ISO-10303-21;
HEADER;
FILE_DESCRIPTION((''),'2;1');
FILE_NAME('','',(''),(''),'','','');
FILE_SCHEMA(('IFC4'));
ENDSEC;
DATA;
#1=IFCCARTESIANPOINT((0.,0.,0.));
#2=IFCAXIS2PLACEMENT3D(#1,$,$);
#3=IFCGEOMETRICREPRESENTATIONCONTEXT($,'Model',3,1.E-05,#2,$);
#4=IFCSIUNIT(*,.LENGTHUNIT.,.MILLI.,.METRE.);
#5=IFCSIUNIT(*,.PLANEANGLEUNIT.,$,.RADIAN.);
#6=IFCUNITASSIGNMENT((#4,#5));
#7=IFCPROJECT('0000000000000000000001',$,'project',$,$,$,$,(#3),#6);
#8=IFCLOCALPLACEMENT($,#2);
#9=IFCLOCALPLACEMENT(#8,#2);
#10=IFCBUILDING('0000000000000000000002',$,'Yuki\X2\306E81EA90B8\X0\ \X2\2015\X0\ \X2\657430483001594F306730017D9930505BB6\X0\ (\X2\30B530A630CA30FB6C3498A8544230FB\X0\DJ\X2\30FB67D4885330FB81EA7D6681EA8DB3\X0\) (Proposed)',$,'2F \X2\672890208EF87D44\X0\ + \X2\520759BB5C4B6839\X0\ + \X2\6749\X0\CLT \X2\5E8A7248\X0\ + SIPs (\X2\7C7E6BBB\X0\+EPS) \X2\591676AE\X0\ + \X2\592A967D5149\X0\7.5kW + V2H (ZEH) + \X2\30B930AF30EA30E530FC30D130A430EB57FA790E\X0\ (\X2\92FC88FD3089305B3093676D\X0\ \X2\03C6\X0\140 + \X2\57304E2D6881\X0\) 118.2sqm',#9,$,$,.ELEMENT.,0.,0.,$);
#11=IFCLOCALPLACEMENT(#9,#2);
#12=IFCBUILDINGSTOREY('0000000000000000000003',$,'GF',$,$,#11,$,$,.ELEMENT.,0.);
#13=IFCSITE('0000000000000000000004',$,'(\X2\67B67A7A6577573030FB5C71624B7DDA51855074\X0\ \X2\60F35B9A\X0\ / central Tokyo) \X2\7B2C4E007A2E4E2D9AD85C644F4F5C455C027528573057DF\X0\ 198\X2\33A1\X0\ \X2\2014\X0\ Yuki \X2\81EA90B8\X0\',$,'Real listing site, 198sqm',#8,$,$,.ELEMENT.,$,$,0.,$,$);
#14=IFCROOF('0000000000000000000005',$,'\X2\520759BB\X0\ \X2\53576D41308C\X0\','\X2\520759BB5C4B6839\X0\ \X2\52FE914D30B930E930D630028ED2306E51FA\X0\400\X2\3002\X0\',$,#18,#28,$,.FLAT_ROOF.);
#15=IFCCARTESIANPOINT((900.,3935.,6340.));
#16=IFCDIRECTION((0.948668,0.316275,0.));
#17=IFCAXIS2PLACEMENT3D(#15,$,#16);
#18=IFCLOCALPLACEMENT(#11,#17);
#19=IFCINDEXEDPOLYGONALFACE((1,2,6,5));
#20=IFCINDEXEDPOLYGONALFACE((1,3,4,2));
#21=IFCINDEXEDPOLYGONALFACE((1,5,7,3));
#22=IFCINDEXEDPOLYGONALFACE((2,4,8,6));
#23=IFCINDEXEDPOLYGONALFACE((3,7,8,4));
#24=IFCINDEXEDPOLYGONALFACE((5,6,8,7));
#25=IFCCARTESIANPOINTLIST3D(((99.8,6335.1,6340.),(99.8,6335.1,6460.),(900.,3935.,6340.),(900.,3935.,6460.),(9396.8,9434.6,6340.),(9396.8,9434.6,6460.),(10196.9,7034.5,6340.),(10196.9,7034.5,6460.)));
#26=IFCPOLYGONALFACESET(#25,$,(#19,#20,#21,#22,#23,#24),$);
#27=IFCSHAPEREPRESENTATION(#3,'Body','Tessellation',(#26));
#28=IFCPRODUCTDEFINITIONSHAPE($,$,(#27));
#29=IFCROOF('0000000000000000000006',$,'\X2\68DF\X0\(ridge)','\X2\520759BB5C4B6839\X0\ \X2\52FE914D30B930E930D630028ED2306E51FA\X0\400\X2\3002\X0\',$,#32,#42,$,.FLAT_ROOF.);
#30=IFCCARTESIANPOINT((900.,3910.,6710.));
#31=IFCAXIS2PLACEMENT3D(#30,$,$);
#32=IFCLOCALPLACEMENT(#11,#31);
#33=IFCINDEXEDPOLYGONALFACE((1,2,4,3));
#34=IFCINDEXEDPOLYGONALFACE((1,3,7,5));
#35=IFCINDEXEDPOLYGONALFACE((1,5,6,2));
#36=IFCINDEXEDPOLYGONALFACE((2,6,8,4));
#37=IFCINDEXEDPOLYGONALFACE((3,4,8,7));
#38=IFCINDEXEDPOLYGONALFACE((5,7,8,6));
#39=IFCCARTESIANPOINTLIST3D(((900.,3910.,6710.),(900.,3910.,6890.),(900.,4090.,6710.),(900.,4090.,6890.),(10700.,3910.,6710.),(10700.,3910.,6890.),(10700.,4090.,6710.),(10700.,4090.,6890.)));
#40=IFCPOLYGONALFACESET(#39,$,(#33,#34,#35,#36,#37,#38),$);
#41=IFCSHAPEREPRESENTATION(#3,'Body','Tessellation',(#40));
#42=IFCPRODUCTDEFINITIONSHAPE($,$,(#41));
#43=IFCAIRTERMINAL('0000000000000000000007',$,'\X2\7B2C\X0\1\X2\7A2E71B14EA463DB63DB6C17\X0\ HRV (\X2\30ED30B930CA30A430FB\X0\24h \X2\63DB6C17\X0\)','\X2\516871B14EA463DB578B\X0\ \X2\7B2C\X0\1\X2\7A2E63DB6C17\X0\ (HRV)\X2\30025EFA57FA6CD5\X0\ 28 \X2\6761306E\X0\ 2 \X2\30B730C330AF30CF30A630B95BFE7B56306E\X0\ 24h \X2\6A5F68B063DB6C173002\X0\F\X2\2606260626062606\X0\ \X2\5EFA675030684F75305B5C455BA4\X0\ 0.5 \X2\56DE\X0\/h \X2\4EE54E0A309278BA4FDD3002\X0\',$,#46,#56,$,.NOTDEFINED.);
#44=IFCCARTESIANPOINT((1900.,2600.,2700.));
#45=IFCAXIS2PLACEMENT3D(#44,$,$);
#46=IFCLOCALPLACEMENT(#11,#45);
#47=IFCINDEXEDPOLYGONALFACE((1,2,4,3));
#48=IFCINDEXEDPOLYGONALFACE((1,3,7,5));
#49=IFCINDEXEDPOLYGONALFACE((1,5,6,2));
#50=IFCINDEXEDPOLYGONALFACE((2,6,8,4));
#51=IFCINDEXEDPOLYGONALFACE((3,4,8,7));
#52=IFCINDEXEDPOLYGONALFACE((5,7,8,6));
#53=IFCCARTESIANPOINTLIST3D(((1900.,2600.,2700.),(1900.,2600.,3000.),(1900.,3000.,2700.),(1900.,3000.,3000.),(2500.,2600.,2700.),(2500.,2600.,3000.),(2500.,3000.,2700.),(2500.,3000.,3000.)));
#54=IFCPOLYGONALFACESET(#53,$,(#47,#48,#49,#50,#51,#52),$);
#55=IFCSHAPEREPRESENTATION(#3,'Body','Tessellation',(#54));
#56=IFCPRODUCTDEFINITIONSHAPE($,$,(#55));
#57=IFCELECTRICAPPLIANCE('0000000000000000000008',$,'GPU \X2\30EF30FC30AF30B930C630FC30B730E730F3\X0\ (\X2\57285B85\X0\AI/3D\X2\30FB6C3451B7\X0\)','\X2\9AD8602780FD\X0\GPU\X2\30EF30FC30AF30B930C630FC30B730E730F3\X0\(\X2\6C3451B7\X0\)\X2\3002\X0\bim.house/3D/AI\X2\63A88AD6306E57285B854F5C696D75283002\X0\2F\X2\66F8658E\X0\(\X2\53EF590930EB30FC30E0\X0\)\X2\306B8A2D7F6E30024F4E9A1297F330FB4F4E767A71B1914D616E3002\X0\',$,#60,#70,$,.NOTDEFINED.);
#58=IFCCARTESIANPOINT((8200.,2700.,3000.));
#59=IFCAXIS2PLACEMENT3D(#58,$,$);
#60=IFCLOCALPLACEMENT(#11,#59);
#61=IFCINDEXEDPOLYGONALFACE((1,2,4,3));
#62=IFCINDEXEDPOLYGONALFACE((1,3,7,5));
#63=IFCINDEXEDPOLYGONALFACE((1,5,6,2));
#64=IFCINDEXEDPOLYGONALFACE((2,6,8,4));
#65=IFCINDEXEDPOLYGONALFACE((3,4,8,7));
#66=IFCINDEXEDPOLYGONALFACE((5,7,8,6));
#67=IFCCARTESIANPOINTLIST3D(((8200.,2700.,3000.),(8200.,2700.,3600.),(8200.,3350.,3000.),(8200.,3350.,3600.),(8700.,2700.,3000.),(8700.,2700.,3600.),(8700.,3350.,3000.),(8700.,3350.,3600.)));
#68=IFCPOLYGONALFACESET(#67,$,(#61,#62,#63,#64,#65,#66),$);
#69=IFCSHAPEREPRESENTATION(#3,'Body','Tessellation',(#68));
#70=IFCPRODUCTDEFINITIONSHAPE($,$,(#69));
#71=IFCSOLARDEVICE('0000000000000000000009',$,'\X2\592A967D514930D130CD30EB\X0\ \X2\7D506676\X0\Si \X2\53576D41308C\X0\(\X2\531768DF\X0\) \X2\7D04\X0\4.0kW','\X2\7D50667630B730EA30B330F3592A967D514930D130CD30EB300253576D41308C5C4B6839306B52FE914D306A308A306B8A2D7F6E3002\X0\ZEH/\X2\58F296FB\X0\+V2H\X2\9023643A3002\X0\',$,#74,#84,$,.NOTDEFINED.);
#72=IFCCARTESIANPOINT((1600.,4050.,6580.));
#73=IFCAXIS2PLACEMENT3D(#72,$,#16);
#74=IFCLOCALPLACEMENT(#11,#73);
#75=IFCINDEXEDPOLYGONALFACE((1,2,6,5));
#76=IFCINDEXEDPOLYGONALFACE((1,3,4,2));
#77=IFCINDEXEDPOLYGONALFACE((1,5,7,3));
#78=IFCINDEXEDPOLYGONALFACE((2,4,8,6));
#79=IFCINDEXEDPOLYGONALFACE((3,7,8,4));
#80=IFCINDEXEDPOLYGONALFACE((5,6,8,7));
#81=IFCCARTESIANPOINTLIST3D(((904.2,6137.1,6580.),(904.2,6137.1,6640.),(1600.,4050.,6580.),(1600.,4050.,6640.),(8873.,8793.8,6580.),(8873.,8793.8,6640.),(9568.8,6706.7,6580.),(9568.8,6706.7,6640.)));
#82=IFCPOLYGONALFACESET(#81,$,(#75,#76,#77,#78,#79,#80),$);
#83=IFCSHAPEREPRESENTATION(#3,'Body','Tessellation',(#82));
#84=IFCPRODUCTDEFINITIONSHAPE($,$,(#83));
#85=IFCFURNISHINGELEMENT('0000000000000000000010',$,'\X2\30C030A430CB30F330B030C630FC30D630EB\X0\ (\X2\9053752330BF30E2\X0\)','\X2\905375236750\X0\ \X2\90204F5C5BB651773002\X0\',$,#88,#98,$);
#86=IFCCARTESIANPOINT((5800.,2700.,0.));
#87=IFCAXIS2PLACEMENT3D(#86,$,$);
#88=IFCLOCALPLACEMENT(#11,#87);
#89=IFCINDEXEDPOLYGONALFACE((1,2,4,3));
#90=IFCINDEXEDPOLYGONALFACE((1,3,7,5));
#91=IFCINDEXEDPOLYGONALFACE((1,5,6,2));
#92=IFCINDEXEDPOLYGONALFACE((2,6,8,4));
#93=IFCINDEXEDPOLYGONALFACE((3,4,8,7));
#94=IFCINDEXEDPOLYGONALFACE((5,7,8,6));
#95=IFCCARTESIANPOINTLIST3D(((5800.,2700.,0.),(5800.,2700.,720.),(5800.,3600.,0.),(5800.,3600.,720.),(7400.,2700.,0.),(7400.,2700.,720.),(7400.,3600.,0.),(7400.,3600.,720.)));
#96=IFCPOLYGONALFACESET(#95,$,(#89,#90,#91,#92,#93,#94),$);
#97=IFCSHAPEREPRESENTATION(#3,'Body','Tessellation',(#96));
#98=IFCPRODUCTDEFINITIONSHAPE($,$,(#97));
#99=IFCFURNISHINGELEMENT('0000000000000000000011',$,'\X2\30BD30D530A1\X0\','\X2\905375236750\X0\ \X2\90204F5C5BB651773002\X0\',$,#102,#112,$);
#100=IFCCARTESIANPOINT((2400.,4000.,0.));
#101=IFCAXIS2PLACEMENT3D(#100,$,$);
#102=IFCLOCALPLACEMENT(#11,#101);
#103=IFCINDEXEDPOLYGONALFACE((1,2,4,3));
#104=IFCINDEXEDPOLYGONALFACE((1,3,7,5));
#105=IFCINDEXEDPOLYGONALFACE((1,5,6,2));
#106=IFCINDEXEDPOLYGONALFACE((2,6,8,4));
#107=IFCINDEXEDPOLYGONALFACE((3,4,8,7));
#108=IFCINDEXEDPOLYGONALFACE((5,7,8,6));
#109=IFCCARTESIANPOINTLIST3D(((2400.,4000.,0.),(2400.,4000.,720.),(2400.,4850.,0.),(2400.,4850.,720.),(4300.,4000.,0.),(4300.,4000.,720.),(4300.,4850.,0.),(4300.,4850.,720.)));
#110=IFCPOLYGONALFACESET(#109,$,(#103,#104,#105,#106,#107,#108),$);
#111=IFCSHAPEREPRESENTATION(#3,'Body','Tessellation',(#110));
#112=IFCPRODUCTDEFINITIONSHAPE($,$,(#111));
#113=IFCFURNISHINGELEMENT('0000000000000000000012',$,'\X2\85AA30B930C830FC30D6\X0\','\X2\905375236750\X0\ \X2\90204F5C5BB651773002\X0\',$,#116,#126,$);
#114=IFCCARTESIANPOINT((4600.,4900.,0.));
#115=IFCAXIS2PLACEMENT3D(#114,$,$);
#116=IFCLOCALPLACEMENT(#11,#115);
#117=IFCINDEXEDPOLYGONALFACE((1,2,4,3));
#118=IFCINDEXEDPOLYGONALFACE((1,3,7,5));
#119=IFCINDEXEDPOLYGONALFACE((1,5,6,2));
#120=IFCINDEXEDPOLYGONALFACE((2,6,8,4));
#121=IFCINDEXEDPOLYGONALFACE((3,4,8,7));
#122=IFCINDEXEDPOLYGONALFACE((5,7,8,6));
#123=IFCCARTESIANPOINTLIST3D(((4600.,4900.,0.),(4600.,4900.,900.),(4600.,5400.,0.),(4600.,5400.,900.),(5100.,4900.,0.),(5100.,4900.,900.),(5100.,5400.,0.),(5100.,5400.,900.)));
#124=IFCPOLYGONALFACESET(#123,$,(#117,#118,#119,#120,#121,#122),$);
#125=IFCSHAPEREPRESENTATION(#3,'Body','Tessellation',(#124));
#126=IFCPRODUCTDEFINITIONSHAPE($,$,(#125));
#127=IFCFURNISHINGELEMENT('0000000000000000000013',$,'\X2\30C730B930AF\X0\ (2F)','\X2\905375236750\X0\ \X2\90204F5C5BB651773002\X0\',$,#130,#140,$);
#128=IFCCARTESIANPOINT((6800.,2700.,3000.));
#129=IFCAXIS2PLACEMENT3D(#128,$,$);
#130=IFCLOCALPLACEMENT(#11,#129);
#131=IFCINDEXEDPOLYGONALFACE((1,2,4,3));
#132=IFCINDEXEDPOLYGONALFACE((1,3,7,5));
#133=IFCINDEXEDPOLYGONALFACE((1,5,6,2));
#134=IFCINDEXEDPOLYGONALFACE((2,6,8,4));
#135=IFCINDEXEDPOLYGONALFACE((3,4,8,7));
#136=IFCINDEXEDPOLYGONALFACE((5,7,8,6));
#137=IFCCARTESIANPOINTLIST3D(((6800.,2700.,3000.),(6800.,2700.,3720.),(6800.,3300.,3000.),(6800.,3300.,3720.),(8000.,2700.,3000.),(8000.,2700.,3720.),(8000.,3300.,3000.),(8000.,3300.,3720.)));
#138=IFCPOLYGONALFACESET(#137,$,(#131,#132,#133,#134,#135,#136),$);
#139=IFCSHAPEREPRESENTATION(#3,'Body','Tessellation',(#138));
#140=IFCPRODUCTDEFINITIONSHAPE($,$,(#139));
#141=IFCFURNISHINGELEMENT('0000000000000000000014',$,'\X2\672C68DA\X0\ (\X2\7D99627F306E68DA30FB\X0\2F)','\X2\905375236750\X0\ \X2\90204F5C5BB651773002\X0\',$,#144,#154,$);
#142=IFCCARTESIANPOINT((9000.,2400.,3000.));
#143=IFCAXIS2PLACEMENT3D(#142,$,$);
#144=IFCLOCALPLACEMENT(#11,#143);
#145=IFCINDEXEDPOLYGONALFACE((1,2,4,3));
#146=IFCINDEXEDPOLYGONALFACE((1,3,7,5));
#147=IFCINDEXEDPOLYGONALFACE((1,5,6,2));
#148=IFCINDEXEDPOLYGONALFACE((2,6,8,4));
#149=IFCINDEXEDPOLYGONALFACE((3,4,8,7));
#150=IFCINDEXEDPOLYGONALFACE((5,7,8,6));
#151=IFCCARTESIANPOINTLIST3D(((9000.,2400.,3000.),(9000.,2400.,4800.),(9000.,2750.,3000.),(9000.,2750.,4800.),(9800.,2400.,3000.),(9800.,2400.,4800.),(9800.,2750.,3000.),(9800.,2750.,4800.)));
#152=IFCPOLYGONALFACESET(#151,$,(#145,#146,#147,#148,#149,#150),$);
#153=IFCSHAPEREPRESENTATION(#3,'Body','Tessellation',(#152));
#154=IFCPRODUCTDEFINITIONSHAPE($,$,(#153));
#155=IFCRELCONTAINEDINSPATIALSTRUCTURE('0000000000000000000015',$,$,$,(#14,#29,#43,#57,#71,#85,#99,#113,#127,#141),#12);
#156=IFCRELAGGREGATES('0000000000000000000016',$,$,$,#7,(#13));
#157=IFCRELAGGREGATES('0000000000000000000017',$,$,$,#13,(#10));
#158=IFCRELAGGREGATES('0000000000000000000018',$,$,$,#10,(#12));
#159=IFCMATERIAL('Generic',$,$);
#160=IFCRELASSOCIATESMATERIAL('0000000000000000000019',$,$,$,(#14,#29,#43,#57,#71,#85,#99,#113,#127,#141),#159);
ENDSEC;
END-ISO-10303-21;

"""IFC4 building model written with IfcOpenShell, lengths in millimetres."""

from ifc_helpers import new_model, si_unit, frame, frame_2d, origin, place, context, project, spatial, rectangle, extrude, material, element, save


model = new_model("IFC4")

# Units and contexts
model_context = context("Model", 3, precision=1e-05, world=origin())
ifc_project = project(units=[si_unit("LENGTHUNIT", "METRE", prefix="MILLI"), si_unit("PLANEANGLEUNIT", "RADIAN")], contexts=[model_context])

# Site, building, storey
site_placement = place(None, origin())
site = spatial("IfcSite", under=ifc_project, at=site_placement, Name="(架空敷地・山手線内側 想定 / central Tokyo) 第一種中高層住居専用地域 198㎡ — Yuki 自邸", ObjectType="Real listing site, 198sqm", CompositionType="ELEMENT", RefElevation=0.0)
building_placement = place(site_placement, origin())
building = spatial("IfcBuilding", under=site, at=building_placement, Name="Yukiの自邸 ― 整え、奏で、継ぐ家 (サウナ・水風呂・DJ・柔術・自給自足) (Proposed)", ObjectType="2F 木造軸組 + 切妻屋根 + 杉CLT 床版 + SIPs (籾殻+EPS) 外皮 + 太陽光7.5kW + V2H (ZEH) + スクリューパイル基礎 (鋼製らせん杭 φ140 + 地中梁) 118.2sqm", CompositionType="ELEMENT", ElevationOfRefHeight=0.0, ElevationOfTerrain=0.0)
storey_placement = place(building_placement, origin())
storey = spatial("IfcBuildingStorey", under=building, at=storey_placement, Name="GF", CompositionType="ELEMENT", Elevation=0.0)

# Shared definitions
ifc_material_1 = material(Name="Generic")

# Roofs
roof_1_placement = place(storey_placement, frame((900.0, 3935.0, 6340.0), x_axis=(0.948668, 0.316275, 0.0)))
element("IfcRoof", 1, at=roof_1_placement, inside=storey, material=ifc_material_1, Name="切妻 南流れ", Description="切妻屋根 勾配スラブ。軒の出400。", PredefinedType="FLAT_ROOF", context=model_context, shape_type="SweptSolid", body=[
    extrude(rectangle(XDim=9800.0, YDim=2530.0, at=frame_2d((4900.0, 1265.0))), frame((900.0, 3935.0, 6340.0), x_axis=(0.948668, 0.316275, 0.0)), (0.0, 0.0, 1.0), 120.0),
])
roof_2_placement = place(storey_placement, frame((900.0, 3910.0, 6710.0)))
element("IfcRoof", 2, at=roof_2_placement, inside=storey, material=ifc_material_1, Name="棟(ridge)", Description="切妻屋根 勾配スラブ。軒の出400。", PredefinedType="FLAT_ROOF", context=model_context, shape_type="SweptSolid", body=[
    extrude(rectangle(XDim=9800.0, YDim=180.0, at=frame_2d((4900.0, 90.0))), frame((900.0, 3910.0, 6710.0)), (0.0, 0.0, 1.0), 180.0),
])

# Air terminal
air_terminal_placement = place(storey_placement, frame((1900.0, 2600.0, 2700.0)))
element("IfcAirTerminal", 3, at=air_terminal_placement, inside=storey, material=ifc_material_1, Name="第1種熱交換換気 HRV (ロスナイ・24h 換気)", Description="全熱交換型 第1種換気 (HRV)。建基法 28 条の 2 シックハウス対策の 24h 機械換気。F☆☆☆☆ 建材と併せ居室 0.5 回/h 以上を確保。", PredefinedType="NOTDEFINED", context=model_context, shape_type="SweptSolid", body=[
    extrude(rectangle(XDim=600.0, YDim=400.0, at=frame_2d((300.0, 200.0))), frame((1900.0, 2600.0, 2700.0)), (0.0, 0.0, 1.0), 300.0),
])

# Electric appliance
electric_appliance_placement = place(storey_placement, frame((8200.0, 2700.0, 3000.0)))
element("IfcElectricAppliance", 4, at=electric_appliance_placement, inside=storey, material=ifc_material_1, Name="GPU ワークステーション (在宅AI/3D・水冷)", Description="高性能GPUワークステーション(水冷)。bim.house/3D/AI推論の在宅作業用。2F書斎(可変ルーム)に設置。低騒音・低発熱配慮。", PredefinedType="NOTDEFINED", context=model_context, shape_type="SweptSolid", body=[
    extrude(rectangle(XDim=500.0, YDim=650.0, at=frame_2d((250.0, 325.0))), frame((8200.0, 2700.0, 3000.0)), (0.0, 0.0, 1.0), 600.0),
])

# Solar device
solar_device_placement = place(storey_placement, frame((1600.0, 4050.0, 6580.0), x_axis=(0.948668, 0.316275, 0.0)))
element("IfcSolarDevice", 5, at=solar_device_placement, inside=storey, material=ifc_material_1, Name="太陽光パネル 結晶Si 南流れ(北棟) 約4.0kW", Description="結晶シリコン太陽光パネル。南流れ屋根に勾配なりに設置。ZEH/売電+V2H連携。", PredefinedType="NOTDEFINED", context=model_context, shape_type="SweptSolid", body=[
    extrude(rectangle(XDim=8400.0, YDim=2200.0, at=frame_2d((4200.0, 1100.0))), frame((1600.0, 4050.0, 6580.0), x_axis=(0.948668, 0.316275, 0.0)), (0.0, 0.0, 1.0), 60.0),
])

# Furnishing elements
furnishing_1_placement = place(storey_placement, frame((5800.0, 2700.0, 0.0)))
element("IfcFurnishingElement", 6, at=furnishing_1_placement, inside=storey, material=ifc_material_1, Name="ダイニングテーブル (道産タモ)", Description="道産材 造作家具。", context=model_context, shape_type="SweptSolid", body=[
    extrude(rectangle(XDim=1600.0, YDim=900.0, at=frame_2d((800.0, 450.0))), frame((5800.0, 2700.0, 0.0)), (0.0, 0.0, 1.0), 720.0),
])
furnishing_2_placement = place(storey_placement, frame((2400.0, 4000.0, 0.0)))
element("IfcFurnishingElement", 7, at=furnishing_2_placement, inside=storey, material=ifc_material_1, Name="ソファ", Description="道産材 造作家具。", context=model_context, shape_type="SweptSolid", body=[
    extrude(rectangle(XDim=1900.0, YDim=850.0, at=frame_2d((950.0, 425.0))), frame((2400.0, 4000.0, 0.0)), (0.0, 0.0, 1.0), 720.0),
])
furnishing_3_placement = place(storey_placement, frame((4600.0, 4900.0, 0.0)))
element("IfcFurnishingElement", 8, at=furnishing_3_placement, inside=storey, material=ifc_material_1, Name="薪ストーブ", Description="道産材 造作家具。", context=model_context, shape_type="SweptSolid", body=[
    extrude(rectangle(XDim=500.0, YDim=500.0, at=frame_2d((250.0, 250.0))), frame((4600.0, 4900.0, 0.0)), (0.0, 0.0, 1.0), 900.0),
])
furnishing_4_placement = place(storey_placement, frame((6800.0, 2700.0, 3000.0)))
element("IfcFurnishingElement", 9, at=furnishing_4_placement, inside=storey, material=ifc_material_1, Name="デスク (2F)", Description="道産材 造作家具。", context=model_context, shape_type="SweptSolid", body=[
    extrude(rectangle(XDim=1200.0, YDim=600.0, at=frame_2d((600.0, 300.0))), frame((6800.0, 2700.0, 3000.0)), (0.0, 0.0, 1.0), 720.0),
])
furnishing_5_placement = place(storey_placement, frame((9000.0, 2400.0, 3000.0)))
element("IfcFurnishingElement", 10, at=furnishing_5_placement, inside=storey, material=ifc_material_1, Name="本棚 (継承の棚・2F)", Description="道産材 造作家具。", context=model_context, shape_type="SweptSolid", body=[
    extrude(rectangle(XDim=800.0, YDim=350.0, at=frame_2d((400.0, 175.0))), frame((9000.0, 2400.0, 3000.0)), (0.0, 0.0, 1.0), 1800.0),
])

save(model, "model.ifc")
